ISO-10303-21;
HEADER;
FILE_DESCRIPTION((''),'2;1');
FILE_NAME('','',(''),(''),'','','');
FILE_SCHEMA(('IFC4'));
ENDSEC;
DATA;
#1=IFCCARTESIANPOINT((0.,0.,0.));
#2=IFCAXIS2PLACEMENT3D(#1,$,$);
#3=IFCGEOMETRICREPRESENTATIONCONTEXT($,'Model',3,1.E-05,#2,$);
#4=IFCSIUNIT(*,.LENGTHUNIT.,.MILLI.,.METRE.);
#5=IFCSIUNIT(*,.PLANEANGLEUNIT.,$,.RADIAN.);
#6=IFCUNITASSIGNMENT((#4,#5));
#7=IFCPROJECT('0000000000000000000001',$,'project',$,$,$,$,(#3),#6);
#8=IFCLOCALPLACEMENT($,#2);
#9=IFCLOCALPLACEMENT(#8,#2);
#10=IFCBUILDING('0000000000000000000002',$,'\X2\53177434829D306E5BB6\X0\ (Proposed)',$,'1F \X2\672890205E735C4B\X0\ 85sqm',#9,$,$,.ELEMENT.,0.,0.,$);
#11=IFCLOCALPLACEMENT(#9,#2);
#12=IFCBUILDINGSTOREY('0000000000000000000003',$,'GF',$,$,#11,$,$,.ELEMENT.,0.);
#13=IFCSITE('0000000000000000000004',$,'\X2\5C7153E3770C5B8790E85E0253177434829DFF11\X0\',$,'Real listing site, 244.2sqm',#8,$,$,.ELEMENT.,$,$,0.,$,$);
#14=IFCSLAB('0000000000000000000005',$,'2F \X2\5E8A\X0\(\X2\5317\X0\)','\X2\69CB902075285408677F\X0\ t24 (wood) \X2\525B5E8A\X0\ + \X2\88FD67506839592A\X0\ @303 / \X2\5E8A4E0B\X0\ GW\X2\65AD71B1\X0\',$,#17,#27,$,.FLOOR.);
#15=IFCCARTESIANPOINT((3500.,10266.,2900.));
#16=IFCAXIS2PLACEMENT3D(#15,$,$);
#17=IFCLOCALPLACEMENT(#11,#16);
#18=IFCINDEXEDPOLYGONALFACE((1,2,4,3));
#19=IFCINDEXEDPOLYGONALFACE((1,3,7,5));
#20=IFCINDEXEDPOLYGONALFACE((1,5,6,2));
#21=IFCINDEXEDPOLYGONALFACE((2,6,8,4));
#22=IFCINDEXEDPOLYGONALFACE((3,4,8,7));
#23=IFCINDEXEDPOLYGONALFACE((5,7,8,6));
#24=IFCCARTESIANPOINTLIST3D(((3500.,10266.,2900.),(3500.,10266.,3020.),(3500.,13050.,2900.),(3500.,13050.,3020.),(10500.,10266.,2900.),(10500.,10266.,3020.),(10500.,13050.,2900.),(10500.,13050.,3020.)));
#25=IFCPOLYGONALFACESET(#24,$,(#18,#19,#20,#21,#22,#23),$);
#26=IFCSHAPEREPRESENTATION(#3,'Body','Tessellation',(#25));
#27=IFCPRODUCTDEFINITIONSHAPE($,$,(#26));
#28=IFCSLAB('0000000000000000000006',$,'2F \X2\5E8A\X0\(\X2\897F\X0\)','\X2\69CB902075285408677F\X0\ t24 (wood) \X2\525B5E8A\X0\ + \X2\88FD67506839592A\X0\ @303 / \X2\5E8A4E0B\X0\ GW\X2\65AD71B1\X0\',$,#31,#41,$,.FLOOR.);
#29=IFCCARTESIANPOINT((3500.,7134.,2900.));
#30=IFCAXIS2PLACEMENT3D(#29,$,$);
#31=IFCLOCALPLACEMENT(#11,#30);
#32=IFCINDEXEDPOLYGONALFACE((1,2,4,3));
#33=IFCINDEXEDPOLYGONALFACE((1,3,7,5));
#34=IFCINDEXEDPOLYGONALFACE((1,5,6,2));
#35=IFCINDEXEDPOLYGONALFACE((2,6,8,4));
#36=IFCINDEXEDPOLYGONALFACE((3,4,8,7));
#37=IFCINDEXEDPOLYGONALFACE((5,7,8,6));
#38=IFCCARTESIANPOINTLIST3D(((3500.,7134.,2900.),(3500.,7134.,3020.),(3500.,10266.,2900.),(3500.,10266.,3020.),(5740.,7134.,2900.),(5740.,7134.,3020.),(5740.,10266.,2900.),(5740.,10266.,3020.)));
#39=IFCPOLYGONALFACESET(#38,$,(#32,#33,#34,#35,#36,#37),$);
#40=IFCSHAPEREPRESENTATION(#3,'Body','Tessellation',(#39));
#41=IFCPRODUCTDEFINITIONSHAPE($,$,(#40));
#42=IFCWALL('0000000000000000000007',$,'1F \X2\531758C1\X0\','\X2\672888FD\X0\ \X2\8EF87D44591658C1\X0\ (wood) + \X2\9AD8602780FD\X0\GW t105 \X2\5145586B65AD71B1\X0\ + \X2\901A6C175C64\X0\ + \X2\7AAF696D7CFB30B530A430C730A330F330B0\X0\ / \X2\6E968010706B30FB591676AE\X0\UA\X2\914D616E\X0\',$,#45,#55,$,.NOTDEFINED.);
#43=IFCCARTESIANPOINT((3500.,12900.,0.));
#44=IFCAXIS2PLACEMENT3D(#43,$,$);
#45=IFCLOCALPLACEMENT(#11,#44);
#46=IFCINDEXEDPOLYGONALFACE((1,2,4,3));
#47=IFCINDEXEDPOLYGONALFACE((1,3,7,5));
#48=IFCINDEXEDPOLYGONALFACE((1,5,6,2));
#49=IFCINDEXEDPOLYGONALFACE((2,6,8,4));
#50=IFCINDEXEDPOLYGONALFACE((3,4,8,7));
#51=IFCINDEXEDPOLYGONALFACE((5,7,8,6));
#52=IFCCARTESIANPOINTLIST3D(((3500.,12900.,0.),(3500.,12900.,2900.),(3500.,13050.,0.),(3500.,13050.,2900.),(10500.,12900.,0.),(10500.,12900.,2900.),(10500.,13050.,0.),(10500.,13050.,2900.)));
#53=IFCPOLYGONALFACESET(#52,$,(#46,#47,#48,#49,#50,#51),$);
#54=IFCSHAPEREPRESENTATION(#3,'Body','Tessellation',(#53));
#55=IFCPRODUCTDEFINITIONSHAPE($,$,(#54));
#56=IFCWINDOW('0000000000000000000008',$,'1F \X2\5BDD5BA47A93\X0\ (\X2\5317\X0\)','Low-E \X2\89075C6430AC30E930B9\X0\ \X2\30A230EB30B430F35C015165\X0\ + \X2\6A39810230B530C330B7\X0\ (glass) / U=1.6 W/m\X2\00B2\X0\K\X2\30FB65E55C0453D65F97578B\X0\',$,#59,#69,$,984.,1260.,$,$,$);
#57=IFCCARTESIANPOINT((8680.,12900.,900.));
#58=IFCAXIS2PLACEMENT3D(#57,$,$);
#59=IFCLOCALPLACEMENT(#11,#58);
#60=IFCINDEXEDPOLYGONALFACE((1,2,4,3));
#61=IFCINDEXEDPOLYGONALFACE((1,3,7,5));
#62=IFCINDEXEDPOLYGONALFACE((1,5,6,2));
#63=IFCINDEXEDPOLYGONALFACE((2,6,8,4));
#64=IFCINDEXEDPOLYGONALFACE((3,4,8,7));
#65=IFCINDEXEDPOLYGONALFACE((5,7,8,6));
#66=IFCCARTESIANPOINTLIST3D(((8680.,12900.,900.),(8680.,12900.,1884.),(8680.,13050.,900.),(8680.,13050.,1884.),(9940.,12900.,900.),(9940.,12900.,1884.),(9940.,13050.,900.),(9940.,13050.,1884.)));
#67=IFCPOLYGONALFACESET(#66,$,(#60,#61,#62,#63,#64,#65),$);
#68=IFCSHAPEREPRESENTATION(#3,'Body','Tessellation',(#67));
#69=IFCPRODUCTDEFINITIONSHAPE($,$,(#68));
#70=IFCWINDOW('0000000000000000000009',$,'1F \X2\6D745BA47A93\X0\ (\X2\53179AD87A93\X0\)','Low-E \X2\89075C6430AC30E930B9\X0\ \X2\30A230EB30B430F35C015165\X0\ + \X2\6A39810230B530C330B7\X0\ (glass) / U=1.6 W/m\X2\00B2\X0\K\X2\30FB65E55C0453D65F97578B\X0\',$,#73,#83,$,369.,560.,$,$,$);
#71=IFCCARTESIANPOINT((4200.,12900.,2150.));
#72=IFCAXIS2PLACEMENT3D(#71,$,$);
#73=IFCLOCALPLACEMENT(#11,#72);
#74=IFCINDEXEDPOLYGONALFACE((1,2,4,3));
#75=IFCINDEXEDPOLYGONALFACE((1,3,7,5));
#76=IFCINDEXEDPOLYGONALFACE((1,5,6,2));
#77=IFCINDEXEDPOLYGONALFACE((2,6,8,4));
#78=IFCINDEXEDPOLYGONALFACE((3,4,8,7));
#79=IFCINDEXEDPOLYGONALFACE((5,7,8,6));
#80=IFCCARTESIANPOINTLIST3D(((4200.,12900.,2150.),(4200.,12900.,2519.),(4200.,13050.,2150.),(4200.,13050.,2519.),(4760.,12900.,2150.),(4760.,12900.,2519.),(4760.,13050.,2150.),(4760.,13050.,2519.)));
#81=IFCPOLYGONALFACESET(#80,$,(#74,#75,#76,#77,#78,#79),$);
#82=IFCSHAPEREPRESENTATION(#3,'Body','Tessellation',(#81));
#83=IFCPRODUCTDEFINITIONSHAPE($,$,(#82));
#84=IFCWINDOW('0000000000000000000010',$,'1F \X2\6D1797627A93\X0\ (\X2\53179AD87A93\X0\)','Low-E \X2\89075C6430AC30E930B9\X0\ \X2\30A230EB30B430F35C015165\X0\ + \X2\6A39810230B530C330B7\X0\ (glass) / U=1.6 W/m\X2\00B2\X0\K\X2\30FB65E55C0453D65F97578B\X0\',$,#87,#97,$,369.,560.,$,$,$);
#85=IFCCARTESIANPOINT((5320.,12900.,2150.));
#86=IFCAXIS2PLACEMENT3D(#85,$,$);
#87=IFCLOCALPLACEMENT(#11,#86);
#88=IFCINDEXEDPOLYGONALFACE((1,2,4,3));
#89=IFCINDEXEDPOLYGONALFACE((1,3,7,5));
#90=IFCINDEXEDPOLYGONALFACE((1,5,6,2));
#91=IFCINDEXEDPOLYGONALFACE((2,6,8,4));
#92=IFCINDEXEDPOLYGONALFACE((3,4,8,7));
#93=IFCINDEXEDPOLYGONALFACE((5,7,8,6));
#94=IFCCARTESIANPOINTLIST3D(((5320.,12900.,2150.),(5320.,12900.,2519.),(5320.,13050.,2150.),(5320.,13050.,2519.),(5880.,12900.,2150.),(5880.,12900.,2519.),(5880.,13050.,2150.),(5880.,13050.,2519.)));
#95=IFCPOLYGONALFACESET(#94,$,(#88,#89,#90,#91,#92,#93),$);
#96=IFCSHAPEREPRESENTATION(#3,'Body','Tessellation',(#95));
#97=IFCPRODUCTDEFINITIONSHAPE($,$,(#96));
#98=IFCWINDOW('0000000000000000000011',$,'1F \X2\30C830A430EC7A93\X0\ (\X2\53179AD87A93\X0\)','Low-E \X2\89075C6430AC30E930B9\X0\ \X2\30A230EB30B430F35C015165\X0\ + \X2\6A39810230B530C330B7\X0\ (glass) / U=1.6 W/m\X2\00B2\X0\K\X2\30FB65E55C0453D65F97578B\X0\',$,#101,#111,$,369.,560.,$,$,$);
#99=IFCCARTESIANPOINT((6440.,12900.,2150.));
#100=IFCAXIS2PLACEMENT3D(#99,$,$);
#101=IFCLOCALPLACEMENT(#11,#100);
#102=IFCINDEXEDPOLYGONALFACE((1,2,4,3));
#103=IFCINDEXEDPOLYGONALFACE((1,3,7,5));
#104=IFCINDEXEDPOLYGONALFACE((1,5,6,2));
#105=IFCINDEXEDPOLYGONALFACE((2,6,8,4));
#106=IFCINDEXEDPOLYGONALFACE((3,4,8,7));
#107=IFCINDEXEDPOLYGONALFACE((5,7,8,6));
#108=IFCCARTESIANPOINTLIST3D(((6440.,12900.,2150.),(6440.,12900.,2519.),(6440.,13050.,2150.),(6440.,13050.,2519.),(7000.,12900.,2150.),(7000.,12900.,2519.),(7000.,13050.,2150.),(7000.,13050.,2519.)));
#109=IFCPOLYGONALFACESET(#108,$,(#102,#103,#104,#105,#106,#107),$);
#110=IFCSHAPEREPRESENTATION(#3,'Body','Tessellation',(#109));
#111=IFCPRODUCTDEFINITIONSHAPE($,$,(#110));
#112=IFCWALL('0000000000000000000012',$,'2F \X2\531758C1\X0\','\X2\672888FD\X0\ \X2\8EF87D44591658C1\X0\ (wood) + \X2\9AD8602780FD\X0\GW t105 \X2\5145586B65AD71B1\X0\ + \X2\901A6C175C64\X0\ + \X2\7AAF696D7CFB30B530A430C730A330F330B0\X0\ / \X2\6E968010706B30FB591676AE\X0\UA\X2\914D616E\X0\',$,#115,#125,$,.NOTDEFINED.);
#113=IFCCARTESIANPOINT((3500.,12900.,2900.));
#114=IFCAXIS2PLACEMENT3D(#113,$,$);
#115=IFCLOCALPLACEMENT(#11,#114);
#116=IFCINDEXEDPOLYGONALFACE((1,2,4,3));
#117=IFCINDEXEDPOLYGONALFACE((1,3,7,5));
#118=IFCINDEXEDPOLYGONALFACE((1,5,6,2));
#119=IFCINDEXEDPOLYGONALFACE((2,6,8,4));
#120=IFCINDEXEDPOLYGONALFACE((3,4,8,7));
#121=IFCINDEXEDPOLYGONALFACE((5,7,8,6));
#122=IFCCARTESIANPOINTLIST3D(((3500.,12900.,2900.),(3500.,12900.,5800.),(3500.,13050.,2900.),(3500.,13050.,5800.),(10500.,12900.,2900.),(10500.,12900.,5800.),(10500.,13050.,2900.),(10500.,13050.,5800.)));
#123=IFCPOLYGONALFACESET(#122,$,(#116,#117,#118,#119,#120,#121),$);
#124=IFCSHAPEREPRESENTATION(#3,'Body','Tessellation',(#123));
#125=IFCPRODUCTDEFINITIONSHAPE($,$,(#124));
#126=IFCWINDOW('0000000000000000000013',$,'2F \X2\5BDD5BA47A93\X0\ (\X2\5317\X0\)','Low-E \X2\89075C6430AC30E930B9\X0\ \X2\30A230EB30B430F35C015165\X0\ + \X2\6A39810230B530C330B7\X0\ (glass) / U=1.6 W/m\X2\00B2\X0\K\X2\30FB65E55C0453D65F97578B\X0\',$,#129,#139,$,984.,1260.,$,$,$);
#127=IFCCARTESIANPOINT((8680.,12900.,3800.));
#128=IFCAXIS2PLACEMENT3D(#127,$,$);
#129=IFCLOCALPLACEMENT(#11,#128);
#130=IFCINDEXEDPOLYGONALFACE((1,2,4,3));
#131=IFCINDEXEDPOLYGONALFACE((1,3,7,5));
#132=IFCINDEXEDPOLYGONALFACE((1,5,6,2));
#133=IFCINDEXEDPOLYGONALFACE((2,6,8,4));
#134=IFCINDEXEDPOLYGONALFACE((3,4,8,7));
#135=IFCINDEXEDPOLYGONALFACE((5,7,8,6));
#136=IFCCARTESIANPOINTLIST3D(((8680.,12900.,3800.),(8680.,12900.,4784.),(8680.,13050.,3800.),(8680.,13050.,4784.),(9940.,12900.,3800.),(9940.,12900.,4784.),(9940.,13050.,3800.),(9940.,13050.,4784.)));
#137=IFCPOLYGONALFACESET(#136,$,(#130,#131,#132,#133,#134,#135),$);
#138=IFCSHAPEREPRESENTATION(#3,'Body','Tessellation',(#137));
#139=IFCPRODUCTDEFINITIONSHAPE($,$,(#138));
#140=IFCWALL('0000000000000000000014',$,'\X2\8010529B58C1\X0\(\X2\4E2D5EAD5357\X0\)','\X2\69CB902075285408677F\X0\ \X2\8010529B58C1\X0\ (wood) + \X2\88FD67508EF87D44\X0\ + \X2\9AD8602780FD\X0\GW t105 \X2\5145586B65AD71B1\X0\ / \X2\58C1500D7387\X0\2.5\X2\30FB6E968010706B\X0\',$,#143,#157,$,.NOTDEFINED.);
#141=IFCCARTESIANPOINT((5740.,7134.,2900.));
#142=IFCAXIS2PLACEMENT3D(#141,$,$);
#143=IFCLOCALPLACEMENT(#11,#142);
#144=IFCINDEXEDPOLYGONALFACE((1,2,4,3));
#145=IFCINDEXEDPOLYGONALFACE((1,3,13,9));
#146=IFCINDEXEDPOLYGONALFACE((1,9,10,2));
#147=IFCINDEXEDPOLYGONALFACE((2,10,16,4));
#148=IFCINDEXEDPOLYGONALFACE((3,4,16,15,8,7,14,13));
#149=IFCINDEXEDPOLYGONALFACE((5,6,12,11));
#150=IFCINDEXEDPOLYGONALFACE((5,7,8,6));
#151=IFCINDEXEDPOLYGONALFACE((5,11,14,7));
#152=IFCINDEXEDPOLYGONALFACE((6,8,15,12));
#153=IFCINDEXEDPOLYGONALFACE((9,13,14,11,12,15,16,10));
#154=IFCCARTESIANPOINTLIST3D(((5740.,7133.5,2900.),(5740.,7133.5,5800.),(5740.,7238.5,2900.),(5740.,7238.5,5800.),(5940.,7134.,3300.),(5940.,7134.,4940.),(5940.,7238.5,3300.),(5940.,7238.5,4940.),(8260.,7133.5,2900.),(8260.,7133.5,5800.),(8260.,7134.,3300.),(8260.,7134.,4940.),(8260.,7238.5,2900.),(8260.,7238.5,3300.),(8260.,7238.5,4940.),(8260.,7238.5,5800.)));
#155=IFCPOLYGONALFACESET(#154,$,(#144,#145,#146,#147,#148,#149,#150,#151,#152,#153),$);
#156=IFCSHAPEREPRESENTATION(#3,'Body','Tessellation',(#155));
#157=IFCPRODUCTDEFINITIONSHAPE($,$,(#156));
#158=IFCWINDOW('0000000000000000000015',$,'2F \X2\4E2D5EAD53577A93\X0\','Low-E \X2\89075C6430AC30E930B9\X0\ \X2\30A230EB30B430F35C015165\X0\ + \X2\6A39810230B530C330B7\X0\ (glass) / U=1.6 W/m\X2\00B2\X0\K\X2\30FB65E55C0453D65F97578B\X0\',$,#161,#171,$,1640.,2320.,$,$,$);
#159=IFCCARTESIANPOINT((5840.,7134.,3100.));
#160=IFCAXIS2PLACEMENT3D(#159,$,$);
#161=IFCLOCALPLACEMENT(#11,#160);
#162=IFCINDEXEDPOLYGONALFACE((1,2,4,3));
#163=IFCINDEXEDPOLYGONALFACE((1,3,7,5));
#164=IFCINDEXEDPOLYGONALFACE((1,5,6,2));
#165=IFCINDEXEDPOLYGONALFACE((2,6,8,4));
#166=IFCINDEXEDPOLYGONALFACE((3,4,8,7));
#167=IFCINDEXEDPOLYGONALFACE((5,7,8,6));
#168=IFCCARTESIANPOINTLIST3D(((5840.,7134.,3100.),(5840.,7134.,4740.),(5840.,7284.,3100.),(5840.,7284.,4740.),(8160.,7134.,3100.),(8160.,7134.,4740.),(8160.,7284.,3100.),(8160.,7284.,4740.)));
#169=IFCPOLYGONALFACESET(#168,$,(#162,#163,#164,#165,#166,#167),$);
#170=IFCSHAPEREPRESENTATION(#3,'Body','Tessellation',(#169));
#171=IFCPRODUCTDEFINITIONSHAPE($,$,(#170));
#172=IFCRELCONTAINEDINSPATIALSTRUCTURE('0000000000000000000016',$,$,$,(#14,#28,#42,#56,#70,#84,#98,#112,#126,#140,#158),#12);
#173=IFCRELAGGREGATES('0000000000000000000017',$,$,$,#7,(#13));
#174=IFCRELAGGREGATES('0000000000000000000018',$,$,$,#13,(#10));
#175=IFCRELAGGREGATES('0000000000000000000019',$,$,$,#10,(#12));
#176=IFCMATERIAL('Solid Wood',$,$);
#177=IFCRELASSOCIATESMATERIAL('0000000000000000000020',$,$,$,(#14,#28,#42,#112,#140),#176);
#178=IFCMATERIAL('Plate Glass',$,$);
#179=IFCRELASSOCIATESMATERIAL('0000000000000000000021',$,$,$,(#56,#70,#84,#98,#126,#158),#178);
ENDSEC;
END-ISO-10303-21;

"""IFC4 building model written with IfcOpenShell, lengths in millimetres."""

from ifc_helpers import new_model, si_unit, frame, frame_2d, origin, place, context, project, spatial, rectangle, extrude, material, element, fill, save


model = new_model("IFC4")

# Units and contexts
model_context = context("Model", 3, precision=1e-05, world=origin())
ifc_project = project(units=[si_unit("LENGTHUNIT", "METRE", prefix="MILLI"), si_unit("PLANEANGLEUNIT", "RADIAN")], contexts=[model_context])

# Site, building, storey
site_placement = place(None, origin())
site = spatial("IfcSite", under=ifc_project, at=site_placement, Name="山口県宇部市北琴芝１", ObjectType="Real listing site, 244.2sqm", CompositionType="ELEMENT", RefElevation=0.0)
building_placement = place(site_placement, origin())
building = spatial("IfcBuilding", under=site, at=building_placement, Name="北琴芝の家 (Proposed)", ObjectType="1F 木造平屋 85sqm", CompositionType="ELEMENT", ElevationOfRefHeight=0.0, ElevationOfTerrain=0.0)
storey_placement = place(building_placement, origin())
storey = spatial("IfcBuildingStorey", under=building, at=storey_placement, Name="GF", CompositionType="ELEMENT", Elevation=0.0)

# Slabs
ifc_material_1 = material(Name="Solid Wood")
slab_1_placement = place(storey_placement, frame((3500.0, 10266.0, 2900.0)))
element("IfcSlab", 1, at=slab_1_placement, inside=storey, material=ifc_material_1, Name="2F 床(北)", Description="構造用合板 t24 (wood) 剛床 + 製材根太 @303 / 床下 GW断熱", PredefinedType="FLOOR", context=model_context, shape_type="SweptSolid", body=[
    extrude(rectangle(XDim=7000.0, YDim=2784.0, at=frame_2d((3500.0, 1392.0))), frame((3500.0, 10266.0, 2900.0)), (0.0, 0.0, 1.0), 120.0),
])
slab_2_placement = place(storey_placement, frame((3500.0, 7134.0, 2900.0)))
element("IfcSlab", 2, at=slab_2_placement, inside=storey, material=ifc_material_1, Name="2F 床(西)", Description="構造用合板 t24 (wood) 剛床 + 製材根太 @303 / 床下 GW断熱", PredefinedType="FLOOR", context=model_context, shape_type="SweptSolid", body=[
    extrude(rectangle(XDim=2240.0, YDim=3132.0, at=frame_2d((1120.0, 1566.0))), frame((3500.0, 7134.0, 2900.0)), (0.0, 0.0, 1.0), 120.0),
])

# Wall, openings, windows
wall_1_placement = place(storey_placement, frame((3500.0, 12900.0, 0.0)))
wall_1 = element("IfcWall", 3, at=wall_1_placement, inside=storey, material=ifc_material_1, Name="1F 北壁", Description="木製 軸組外壁 (wood) + 高性能GW t105 充填断熱 + 通気層 + 窯業系サイディング / 準耐火・外皮UA配慮", PredefinedType="NOTDEFINED", context=model_context, shape_type="SweptSolid", body=[
    extrude(rectangle(XDim=7000.0, YDim=150.0, at=frame_2d((3500.0, 75.0))), frame((3500.0, 12900.0, 0.0)), (0.0, 0.0, 1.0), 2900.0),
])
opening_1_placement = place(storey_placement, frame((8680.0, 12900.0, 900.0)))
opening_1 = element("IfcOpeningElement", 4, at=opening_1_placement, cuts=wall_1, PredefinedType="NOTDEFINED", context=model_context, shape_type="SweptSolid", body=[
    extrude(rectangle(XDim=1260.0, YDim=150.0, at=frame_2d((630.0, 75.0))), frame((8680.0, 12900.0, 900.0)), (0.0, 0.0, 1.0), 984.0),
])
opening_2_placement = place(storey_placement, frame((4200.0, 12900.0, 2150.0)))
opening_2 = element("IfcOpeningElement", 5, at=opening_2_placement, cuts=wall_1, PredefinedType="NOTDEFINED", context=model_context, shape_type="SweptSolid", body=[
    extrude(rectangle(XDim=560.0, YDim=150.0, at=frame_2d((280.0, 75.0))), frame((4200.0, 12900.0, 2150.0)), (0.0, 0.0, 1.0), 369.0),
])
opening_3_placement = place(storey_placement, frame((5320.0, 12900.0, 2150.0)))
opening_3 = element("IfcOpeningElement", 6, at=opening_3_placement, cuts=wall_1, PredefinedType="NOTDEFINED", context=model_context, shape_type="SweptSolid", body=[
    extrude(rectangle(XDim=560.0, YDim=150.0, at=frame_2d((280.0, 75.0))), frame((5320.0, 12900.0, 2150.0)), (0.0, 0.0, 1.0), 369.0),
])
opening_4_placement = place(storey_placement, frame((6440.0, 12900.0, 2150.0)))
opening_4 = element("IfcOpeningElement", 7, at=opening_4_placement, cuts=wall_1, PredefinedType="NOTDEFINED", context=model_context, shape_type="SweptSolid", body=[
    extrude(rectangle(XDim=560.0, YDim=150.0, at=frame_2d((280.0, 75.0))), frame((6440.0, 12900.0, 2150.0)), (0.0, 0.0, 1.0), 369.0),
])
ifc_material_2 = material(Name="Plate Glass")
window_1_placement = place(storey_placement, frame((8680.0, 12900.0, 900.0)))
window_1 = element("IfcWindow", 8, at=window_1_placement, inside=storey, material=ifc_material_2, Name="1F 寝室窓 (北)", Description="Low-E 複層ガラス アルゴン封入 + 樹脂サッシ (glass) / U=1.6 W/m²K・日射取得型", OverallHeight=984.0, OverallWidth=1260.0, context=model_context, shape_type="SweptSolid", body=[
    extrude(rectangle(XDim=1260.0, YDim=150.0, at=frame_2d((630.0, 75.0))), frame((8680.0, 12900.0, 900.0)), (0.0, 0.0, 1.0), 984.0),
])
fill(opening_1, window_1)
window_2_placement = place(storey_placement, frame((4200.0, 12900.0, 2150.0)))
window_2 = element("IfcWindow", 9, at=window_2_placement, inside=storey, material=ifc_material_2, Name="1F 浴室窓 (北高窓)", Description="Low-E 複層ガラス アルゴン封入 + 樹脂サッシ (glass) / U=1.6 W/m²K・日射取得型", OverallHeight=369.0, OverallWidth=560.0, context=model_context, shape_type="SweptSolid", body=[
    extrude(rectangle(XDim=560.0, YDim=150.0, at=frame_2d((280.0, 75.0))), frame((4200.0, 12900.0, 2150.0)), (0.0, 0.0, 1.0), 369.0),
])
fill(opening_2, window_2)
window_3_placement = place(storey_placement, frame((5320.0, 12900.0, 2150.0)))
window_3 = element("IfcWindow", 10, at=window_3_placement, inside=storey, material=ifc_material_2, Name="1F 洗面窓 (北高窓)", Description="Low-E 複層ガラス アルゴン封入 + 樹脂サッシ (glass) / U=1.6 W/m²K・日射取得型", OverallHeight=369.0, OverallWidth=560.0, context=model_context, shape_type="SweptSolid", body=[
    extrude(rectangle(XDim=560.0, YDim=150.0, at=frame_2d((280.0, 75.0))), frame((5320.0, 12900.0, 2150.0)), (0.0, 0.0, 1.0), 369.0),
])
fill(opening_3, window_3)
window_4_placement = place(storey_placement, frame((6440.0, 12900.0, 2150.0)))
window_4 = element("IfcWindow", 11, at=window_4_placement, inside=storey, material=ifc_material_2, Name="1F トイレ窓 (北高窓)", Description="Low-E 複層ガラス アルゴン封入 + 樹脂サッシ (glass) / U=1.6 W/m²K・日射取得型", OverallHeight=369.0, OverallWidth=560.0, context=model_context, shape_type="SweptSolid", body=[
    extrude(rectangle(XDim=560.0, YDim=150.0, at=frame_2d((280.0, 75.0))), frame((6440.0, 12900.0, 2150.0)), (0.0, 0.0, 1.0), 369.0),
])
fill(opening_4, window_4)

# Walls, openings, windows
wall_2_placement = place(storey_placement, frame((3500.0, 12900.0, 2900.0)))
wall_2 = element("IfcWall", 12, at=wall_2_placement, inside=storey, material=ifc_material_1, Name="2F 北壁", Description="木製 軸組外壁 (wood) + 高性能GW t105 充填断熱 + 通気層 + 窯業系サイディング / 準耐火・外皮UA配慮", PredefinedType="NOTDEFINED", context=model_context, shape_type="SweptSolid", body=[
    extrude(rectangle(XDim=7000.0, YDim=150.0, at=frame_2d((3500.0, 75.0))), frame((3500.0, 12900.0, 2900.0)), (0.0, 0.0, 1.0), 2900.0),
])
opening_5_placement = place(storey_placement, frame((8680.0, 12900.0, 3800.0)))
opening_5 = element("IfcOpeningElement", 13, at=opening_5_placement, cuts=wall_2, PredefinedType="NOTDEFINED", context=model_context, shape_type="SweptSolid", body=[
    extrude(rectangle(XDim=1260.0, YDim=150.0, at=frame_2d((630.0, 75.0))), frame((8680.0, 12900.0, 3800.0)), (0.0, 0.0, 1.0), 984.0),
])
window_5_placement = place(storey_placement, frame((8680.0, 12900.0, 3800.0)))
window_5 = element("IfcWindow", 14, at=window_5_placement, inside=storey, material=ifc_material_2, Name="2F 寝室窓 (北)", Description="Low-E 複層ガラス アルゴン封入 + 樹脂サッシ (glass) / U=1.6 W/m²K・日射取得型", OverallHeight=984.0, OverallWidth=1260.0, context=model_context, shape_type="SweptSolid", body=[
    extrude(rectangle(XDim=1260.0, YDim=150.0, at=frame_2d((630.0, 75.0))), frame((8680.0, 12900.0, 3800.0)), (0.0, 0.0, 1.0), 984.0),
])
fill(opening_5, window_5)
wall_3_placement = place(storey_placement, frame((5740.0, 7134.0, 2900.0)))
wall_3 = element("IfcWall", 15, at=wall_3_placement, inside=storey, material=ifc_material_1, Name="耐力壁(中庭南)", Description="構造用合板 耐力壁 (wood) + 製材軸組 + 高性能GW t105 充填断熱 / 壁倍率2.5・準耐火", PredefinedType="NOTDEFINED", context=model_context, shape_type="SweptSolid", body=[
    extrude(rectangle(XDim=2520.0, YDim=105.0, at=frame_2d((1260.0, 52.0))), frame((5740.0, 7134.0, 2900.0)), (0.0, 0.0, 1.0), 2900.0),
])
opening_6_placement = place(storey_placement, frame((5840.0, 7134.0, 3100.0)))
opening_6 = element("IfcOpeningElement", 16, at=opening_6_placement, cuts=wall_3, PredefinedType="NOTDEFINED", context=model_context, shape_type="SweptSolid", body=[
    extrude(rectangle(XDim=2320.0, YDim=150.0, at=frame_2d((1160.0, 75.0))), frame((5840.0, 7134.0, 3100.0)), (0.0, 0.0, 1.0), 1640.0),
])
window_6_placement = place(storey_placement, frame((5840.0, 7134.0, 3100.0)))
window_6 = element("IfcWindow", 17, at=window_6_placement, inside=storey, material=ifc_material_2, Name="2F 中庭南窓", Description="Low-E 複層ガラス アルゴン封入 + 樹脂サッシ (glass) / U=1.6 W/m²K・日射取得型", OverallHeight=1640.0, OverallWidth=2320.0, context=model_context, shape_type="SweptSolid", body=[
    extrude(rectangle(XDim=2320.0, YDim=150.0, at=frame_2d((1160.0, 75.0))), frame((5840.0, 7134.0, 3100.0)), (0.0, 0.0, 1.0), 1640.0),
])
fill(opening_6, window_6)

save(model, "model.ifc")
